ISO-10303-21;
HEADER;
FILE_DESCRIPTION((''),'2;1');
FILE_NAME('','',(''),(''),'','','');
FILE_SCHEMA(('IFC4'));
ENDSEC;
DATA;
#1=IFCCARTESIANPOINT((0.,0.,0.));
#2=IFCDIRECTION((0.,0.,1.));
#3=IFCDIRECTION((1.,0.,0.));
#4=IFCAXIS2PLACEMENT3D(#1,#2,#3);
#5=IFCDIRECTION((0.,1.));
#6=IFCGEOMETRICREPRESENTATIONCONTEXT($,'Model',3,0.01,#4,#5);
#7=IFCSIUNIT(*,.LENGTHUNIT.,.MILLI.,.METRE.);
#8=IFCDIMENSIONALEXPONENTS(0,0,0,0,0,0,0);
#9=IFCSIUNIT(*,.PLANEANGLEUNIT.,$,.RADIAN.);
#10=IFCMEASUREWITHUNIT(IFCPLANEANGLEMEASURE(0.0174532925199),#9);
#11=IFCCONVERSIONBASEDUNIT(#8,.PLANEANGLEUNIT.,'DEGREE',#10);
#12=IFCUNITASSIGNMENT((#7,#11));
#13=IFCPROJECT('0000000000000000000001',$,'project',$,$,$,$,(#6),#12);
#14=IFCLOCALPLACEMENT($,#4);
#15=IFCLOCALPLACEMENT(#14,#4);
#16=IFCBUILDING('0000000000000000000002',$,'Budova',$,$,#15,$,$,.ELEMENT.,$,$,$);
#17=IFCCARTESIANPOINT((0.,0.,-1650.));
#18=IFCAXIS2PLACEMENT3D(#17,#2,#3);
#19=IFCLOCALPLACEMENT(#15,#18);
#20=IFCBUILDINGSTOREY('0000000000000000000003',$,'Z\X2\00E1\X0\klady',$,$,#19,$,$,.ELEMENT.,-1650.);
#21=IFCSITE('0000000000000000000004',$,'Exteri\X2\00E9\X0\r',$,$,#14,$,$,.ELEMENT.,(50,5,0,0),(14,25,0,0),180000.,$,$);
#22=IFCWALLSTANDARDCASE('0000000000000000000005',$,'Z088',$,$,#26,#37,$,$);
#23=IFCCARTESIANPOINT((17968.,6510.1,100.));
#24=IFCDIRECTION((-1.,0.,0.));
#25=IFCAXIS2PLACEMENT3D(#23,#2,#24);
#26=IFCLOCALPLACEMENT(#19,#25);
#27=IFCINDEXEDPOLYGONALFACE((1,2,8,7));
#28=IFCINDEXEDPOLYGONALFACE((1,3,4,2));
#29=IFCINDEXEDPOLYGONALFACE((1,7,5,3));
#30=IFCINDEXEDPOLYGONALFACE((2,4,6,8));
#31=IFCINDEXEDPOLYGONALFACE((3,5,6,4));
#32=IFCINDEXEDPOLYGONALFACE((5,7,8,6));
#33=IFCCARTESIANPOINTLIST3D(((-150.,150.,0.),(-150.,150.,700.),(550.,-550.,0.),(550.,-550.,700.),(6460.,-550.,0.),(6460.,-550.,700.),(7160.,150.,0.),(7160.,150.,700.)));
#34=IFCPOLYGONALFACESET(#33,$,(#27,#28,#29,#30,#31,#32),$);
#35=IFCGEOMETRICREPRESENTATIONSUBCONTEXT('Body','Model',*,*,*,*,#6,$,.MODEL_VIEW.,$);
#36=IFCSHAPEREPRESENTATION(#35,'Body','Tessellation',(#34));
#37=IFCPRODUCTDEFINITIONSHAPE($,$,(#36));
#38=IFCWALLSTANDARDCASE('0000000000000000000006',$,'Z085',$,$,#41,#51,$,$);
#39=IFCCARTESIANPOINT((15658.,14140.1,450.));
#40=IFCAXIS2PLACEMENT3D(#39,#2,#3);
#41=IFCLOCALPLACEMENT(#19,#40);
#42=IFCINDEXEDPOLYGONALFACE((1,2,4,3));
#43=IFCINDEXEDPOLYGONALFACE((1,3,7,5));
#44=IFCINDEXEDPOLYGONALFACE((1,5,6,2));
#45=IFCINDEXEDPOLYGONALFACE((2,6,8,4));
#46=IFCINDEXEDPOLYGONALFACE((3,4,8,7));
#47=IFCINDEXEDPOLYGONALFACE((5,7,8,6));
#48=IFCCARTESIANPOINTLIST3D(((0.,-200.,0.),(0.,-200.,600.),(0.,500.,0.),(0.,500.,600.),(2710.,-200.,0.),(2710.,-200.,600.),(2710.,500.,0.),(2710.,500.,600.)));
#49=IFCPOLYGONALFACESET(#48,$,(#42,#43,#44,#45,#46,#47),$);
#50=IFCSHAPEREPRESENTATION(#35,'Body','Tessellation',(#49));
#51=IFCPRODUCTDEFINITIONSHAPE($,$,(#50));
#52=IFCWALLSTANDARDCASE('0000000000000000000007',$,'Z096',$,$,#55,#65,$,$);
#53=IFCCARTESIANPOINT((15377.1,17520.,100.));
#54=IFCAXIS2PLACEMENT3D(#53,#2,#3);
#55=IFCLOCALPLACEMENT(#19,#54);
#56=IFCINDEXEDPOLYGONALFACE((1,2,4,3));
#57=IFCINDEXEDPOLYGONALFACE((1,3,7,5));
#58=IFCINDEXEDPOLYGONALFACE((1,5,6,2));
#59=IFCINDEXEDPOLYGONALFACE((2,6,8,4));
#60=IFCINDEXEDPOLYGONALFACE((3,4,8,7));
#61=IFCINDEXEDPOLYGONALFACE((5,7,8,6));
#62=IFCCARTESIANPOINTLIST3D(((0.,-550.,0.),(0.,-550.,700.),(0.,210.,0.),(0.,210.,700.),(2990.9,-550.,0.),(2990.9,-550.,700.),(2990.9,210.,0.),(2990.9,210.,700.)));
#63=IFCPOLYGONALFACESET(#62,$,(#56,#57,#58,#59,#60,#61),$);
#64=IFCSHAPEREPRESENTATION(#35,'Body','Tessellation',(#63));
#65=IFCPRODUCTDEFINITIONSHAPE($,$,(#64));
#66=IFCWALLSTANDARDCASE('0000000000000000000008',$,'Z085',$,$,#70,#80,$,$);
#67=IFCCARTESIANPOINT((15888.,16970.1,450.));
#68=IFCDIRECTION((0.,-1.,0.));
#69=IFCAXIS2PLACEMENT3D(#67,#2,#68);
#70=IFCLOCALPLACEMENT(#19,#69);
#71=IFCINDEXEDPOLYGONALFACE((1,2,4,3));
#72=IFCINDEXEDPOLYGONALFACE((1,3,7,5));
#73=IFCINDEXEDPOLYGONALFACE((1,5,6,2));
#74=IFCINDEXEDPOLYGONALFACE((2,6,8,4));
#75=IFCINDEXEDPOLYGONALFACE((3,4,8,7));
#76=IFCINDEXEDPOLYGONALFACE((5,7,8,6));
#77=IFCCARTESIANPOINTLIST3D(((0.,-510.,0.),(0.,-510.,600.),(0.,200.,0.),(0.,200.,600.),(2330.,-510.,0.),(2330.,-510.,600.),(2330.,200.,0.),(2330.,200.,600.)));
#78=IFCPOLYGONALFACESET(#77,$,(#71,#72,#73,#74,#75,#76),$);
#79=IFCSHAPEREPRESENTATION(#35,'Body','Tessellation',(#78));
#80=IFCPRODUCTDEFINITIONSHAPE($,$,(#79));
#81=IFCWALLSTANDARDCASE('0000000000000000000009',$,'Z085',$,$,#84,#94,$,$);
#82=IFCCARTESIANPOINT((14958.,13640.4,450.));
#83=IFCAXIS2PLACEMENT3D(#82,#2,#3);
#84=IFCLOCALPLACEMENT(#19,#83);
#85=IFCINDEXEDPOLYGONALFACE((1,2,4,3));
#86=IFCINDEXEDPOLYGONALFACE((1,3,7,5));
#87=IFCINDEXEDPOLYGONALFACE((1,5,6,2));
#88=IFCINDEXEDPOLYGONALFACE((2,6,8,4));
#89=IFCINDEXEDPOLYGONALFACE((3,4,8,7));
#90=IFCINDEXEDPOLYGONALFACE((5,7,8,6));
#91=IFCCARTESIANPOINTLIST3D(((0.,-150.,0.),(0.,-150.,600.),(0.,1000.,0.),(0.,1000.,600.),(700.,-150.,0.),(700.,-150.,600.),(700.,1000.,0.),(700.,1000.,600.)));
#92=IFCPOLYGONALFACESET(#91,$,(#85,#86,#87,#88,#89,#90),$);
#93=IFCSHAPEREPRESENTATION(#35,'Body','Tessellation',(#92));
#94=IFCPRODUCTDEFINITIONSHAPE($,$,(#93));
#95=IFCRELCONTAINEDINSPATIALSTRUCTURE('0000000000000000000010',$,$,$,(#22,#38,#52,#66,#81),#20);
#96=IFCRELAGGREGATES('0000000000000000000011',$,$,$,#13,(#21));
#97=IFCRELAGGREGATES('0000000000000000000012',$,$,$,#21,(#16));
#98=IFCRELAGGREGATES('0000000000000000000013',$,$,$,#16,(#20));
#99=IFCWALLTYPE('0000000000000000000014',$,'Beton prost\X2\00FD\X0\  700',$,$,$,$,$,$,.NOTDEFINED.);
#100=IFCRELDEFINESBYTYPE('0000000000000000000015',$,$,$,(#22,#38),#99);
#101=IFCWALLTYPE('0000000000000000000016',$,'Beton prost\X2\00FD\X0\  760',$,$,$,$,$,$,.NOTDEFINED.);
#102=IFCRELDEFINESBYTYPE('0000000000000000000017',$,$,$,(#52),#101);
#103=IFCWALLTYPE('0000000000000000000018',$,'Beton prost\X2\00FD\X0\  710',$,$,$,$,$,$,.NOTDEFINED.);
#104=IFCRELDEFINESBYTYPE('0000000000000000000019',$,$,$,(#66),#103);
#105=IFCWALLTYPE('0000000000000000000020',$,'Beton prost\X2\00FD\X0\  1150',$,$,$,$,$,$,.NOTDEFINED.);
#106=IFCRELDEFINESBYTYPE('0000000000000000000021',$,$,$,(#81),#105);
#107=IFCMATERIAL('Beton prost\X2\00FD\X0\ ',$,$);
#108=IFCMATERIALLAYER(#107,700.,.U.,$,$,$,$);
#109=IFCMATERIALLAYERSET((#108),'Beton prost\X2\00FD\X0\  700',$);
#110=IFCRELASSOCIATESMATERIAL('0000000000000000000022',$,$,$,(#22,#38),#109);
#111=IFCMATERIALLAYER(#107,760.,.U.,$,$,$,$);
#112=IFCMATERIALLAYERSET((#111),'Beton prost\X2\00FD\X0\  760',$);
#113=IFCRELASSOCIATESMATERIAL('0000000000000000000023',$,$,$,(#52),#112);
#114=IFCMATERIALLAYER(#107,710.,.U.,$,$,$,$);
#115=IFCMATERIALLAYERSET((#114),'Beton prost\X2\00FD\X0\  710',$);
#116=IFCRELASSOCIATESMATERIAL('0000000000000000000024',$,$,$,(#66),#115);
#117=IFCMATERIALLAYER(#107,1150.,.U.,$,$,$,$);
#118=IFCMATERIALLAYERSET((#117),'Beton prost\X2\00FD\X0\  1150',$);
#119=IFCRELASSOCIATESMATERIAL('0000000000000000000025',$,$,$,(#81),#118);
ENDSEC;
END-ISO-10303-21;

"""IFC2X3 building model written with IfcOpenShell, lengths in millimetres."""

from ifc_helpers import new_model, entity, si_unit, converted_unit, direction, frame, origin_with_axes, place, context, subcontext, project, spatial, polyline, outline, extrude, material, layer, layer_set, layer_usage, type_object, element, save


model = new_model("IFC2X3")

# Units and contexts
model_context = context("Model", 3, precision=0.01, world=origin_with_axes(), true_north=direction((0.0, 1.0)))
body_context = subcontext(model_context, "Body", "Model", "MODEL_VIEW")
ifc_project = project(units=[si_unit("LENGTHUNIT", "METRE", prefix="MILLI"), converted_unit("PLANEANGLEUNIT", "DEGREE", entity("IfcPlaneAngleMeasure", 0.0174532925199), si_unit("PLANEANGLEUNIT", "RADIAN"), dimensions=[0, 0, 0, 0, 0, 0, 0])], contexts=[model_context])

# Site, building, storey
site_placement = place(None, origin_with_axes())
site = spatial("IfcSite", under=ifc_project, at=site_placement, Name="Exteriér", CompositionType="ELEMENT", RefLatitude=(50, 5, 0, 0), RefLongitude=(14, 25, 0, 0), RefElevation=180000.0)
building_placement = place(site_placement, origin_with_axes())
building = spatial("IfcBuilding", under=site, at=building_placement, Name="Budova", CompositionType="ELEMENT")
storey_placement = place(building_placement, frame((0.0, 0.0, -1650.0), z_axis=(0.0, 0.0, 1.0), x_axis=(1.0, 0.0, 0.0)))
storey = spatial("IfcBuildingStorey", under=building, at=storey_placement, Name="Základy", CompositionType="ELEMENT", Elevation=-1650.0)

# Walls
ifc_material_1 = material(Name="Beton prostý ")
ifc_layer_1 = layer(ifc_material_1, 700.0, ventilated="UNKNOWN")
ifc_layer_set_1 = layer_set([ifc_layer_1], Name="Beton prostý  700")
wall_type_1 = type_object("IfcWallType", Name="Beton prostý  700", PredefinedType="NOTDEFINED")
ifc_layer_usage_1 = layer_usage(ifc_layer_set_1, "AXIS2", "POSITIVE", -550.0)
wall_1_placement = place(storey_placement, frame((17968.0, 6510.1, 100.0), z_axis=(0.0, 0.0, 1.0), x_axis=(-1.0, 0.0, 0.0)))
element("IfcWallStandardCase", 1, at=wall_1_placement, inside=storey, type_object=wall_type_1, material=ifc_layer_usage_1, Name="Z088", context=body_context, shape_type="SweptSolid", body=[
    extrude(outline(polyline([(550.0, -550.0), (6460.0, -550.0), (7160.0, 150.0), (-150.0, 150.0), (550.0, -550.0)])), origin_with_axes(), (0.0, 0.0, 1.0), 700.0),
])
ifc_layer_usage_2 = layer_usage(ifc_layer_set_1, "AXIS2", "POSITIVE", -200.0)
wall_2_placement = place(storey_placement, frame((15658.0, 14140.1, 450.0), z_axis=(0.0, 0.0, 1.0), x_axis=(1.0, 0.0, 0.0)))
element("IfcWallStandardCase", 2, at=wall_2_placement, inside=storey, type_object=wall_type_1, material=ifc_layer_usage_2, Name="Z085", context=body_context, shape_type="SweptSolid", body=[
    extrude(outline(polyline([(0.0, -200.0), (2710.0, -200.0), (2710.0, 500.0), (0.0, 500.0), (0.0, -200.0)])), origin_with_axes(), (0.0, 0.0, 1.0), 600.0),
])
ifc_layer_2 = layer(ifc_material_1, 760.0, ventilated="UNKNOWN")
ifc_layer_set_2 = layer_set([ifc_layer_2], Name="Beton prostý  760")
ifc_layer_usage_3 = layer_usage(ifc_layer_set_2, "AXIS2", "POSITIVE", -550.0)
wall_type_2 = type_object("IfcWallType", Name="Beton prostý  760", PredefinedType="NOTDEFINED")
wall_3_placement = place(storey_placement, frame((15377.1, 17520.0, 100.0), z_axis=(0.0, 0.0, 1.0), x_axis=(1.0, 0.0, 0.0)))
element("IfcWallStandardCase", 3, at=wall_3_placement, inside=storey, type_object=wall_type_2, material=ifc_layer_usage_3, Name="Z096", context=body_context, shape_type="SweptSolid", body=[
    extrude(outline(polyline([(0.0, -550.0), (2990.9, -550.0), (2990.9, 210.0), (0.0, 210.0), (0.0, -550.0)])), origin_with_axes(), (0.0, 0.0, 1.0), 700.0),
])
ifc_layer_3 = layer(ifc_material_1, 710.0, ventilated="UNKNOWN")
ifc_layer_set_3 = layer_set([ifc_layer_3], Name="Beton prostý  710")
ifc_layer_usage_4 = layer_usage(ifc_layer_set_3, "AXIS2", "NEGATIVE", 200.0)
wall_type_3 = type_object("IfcWallType", Name="Beton prostý  710", PredefinedType="NOTDEFINED")
wall_4_placement = place(storey_placement, frame((15888.0, 16970.1, 450.0), z_axis=(0.0, 0.0, 1.0), x_axis=(0.0, -1.0, 0.0)))
element("IfcWallStandardCase", 4, at=wall_4_placement, inside=storey, type_object=wall_type_3, material=ifc_layer_usage_4, Name="Z085", context=body_context, shape_type="SweptSolid", body=[
    extrude(outline(polyline([(0.0, -510.0), (2330.0, -510.0), (2330.0, 200.0), (0.0, 200.0), (0.0, -510.0)])), origin_with_axes(), (0.0, 0.0, 1.0), 600.0),
])
ifc_layer_4 = layer(ifc_material_1, 1150.0, ventilated="UNKNOWN")
ifc_layer_set_4 = layer_set([ifc_layer_4], Name="Beton prostý  1150")
ifc_layer_usage_5 = layer_usage(ifc_layer_set_4, "AXIS2", "POSITIVE", -150.0)
wall_type_4 = type_object("IfcWallType", Name="Beton prostý  1150", PredefinedType="NOTDEFINED")
wall_5_placement = place(storey_placement, frame((14958.0, 13640.4, 450.0), z_axis=(0.0, 0.0, 1.0), x_axis=(1.0, 0.0, 0.0)))
element("IfcWallStandardCase", 5, at=wall_5_placement, inside=storey, type_object=wall_type_4, material=ifc_layer_usage_5, Name="Z085", context=body_context, shape_type="SweptSolid", body=[
    extrude(outline(polyline([(0.0, -150.0), (700.0, -150.0), (700.0, 1000.0), (0.0, 1000.0), (0.0, -150.0)])), origin_with_axes(), (0.0, 0.0, 1.0), 600.0),
])

save(model, "model.ifc")
